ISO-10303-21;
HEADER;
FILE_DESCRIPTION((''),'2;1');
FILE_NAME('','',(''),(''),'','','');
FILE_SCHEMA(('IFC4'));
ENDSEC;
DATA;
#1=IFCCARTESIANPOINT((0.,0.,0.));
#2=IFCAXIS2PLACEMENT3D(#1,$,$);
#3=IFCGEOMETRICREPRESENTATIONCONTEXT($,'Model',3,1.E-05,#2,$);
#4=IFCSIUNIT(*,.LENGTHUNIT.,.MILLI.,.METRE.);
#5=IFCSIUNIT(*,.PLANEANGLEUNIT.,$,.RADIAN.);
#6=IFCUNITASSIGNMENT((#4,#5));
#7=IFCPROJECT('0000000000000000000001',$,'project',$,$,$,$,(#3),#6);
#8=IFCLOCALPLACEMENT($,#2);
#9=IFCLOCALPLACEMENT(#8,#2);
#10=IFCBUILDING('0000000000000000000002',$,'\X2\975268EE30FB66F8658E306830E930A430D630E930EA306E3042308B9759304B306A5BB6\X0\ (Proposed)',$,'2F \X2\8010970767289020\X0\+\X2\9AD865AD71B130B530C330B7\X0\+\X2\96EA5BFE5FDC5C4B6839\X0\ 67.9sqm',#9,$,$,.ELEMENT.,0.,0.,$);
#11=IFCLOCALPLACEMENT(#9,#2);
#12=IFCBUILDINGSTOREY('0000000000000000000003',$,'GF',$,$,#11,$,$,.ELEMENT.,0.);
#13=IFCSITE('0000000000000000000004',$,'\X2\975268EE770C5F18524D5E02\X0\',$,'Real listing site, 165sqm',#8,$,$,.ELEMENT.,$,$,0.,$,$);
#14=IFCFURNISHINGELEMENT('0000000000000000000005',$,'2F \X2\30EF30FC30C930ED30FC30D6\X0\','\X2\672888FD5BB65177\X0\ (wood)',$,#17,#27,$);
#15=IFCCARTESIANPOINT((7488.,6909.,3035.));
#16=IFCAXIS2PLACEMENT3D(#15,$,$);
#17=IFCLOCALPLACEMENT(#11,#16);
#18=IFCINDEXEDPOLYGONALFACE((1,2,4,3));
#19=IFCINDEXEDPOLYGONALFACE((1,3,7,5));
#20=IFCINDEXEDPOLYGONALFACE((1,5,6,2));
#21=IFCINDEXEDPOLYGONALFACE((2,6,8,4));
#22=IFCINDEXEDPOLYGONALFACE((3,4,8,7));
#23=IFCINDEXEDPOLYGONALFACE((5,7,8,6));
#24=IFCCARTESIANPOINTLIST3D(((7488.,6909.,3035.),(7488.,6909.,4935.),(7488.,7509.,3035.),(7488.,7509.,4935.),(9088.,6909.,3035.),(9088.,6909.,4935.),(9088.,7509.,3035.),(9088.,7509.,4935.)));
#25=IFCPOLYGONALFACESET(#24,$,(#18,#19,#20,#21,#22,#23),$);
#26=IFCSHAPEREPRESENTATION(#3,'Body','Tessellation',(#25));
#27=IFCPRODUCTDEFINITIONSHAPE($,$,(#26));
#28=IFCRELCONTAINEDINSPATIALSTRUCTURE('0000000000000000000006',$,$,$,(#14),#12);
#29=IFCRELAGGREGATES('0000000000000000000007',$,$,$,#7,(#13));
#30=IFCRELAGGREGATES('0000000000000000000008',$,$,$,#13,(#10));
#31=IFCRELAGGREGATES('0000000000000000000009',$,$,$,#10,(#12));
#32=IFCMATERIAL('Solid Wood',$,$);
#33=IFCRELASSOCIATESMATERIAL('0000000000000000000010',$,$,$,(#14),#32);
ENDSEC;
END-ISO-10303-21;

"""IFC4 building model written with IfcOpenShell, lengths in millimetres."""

from ifc_helpers import new_model, si_unit, frame, frame_2d, origin, place, context, project, spatial, rectangle, extrude, material, element, save


model = new_model("IFC4")

# Units and contexts
model_context = context("Model", 3, precision=1e-05, world=origin())
ifc_project = project(units=[si_unit("LENGTHUNIT", "METRE", prefix="MILLI"), si_unit("PLANEANGLEUNIT", "RADIAN")], contexts=[model_context])

# Site, building, storey
site_placement = place(None, origin())
site = spatial("IfcSite", under=ifc_project, at=site_placement, Name="青森県弘前市", ObjectType="Real listing site, 165sqm", CompositionType="ELEMENT", RefElevation=0.0)
building_placement = place(site_placement, origin())
building = spatial("IfcBuilding", under=site, at=building_placement, Name="青森・書斎とライブラリのある静かな家 (Proposed)", ObjectType="2F 耐震木造+高断熱サッシ+雪対応屋根 67.9sqm", CompositionType="ELEMENT", ElevationOfRefHeight=0.0, ElevationOfTerrain=0.0)
storey_placement = place(building_placement, origin())
storey = spatial("IfcBuildingStorey", under=building, at=storey_placement, Name="GF", CompositionType="ELEMENT", Elevation=0.0)

# Shared definitions
ifc_material_1 = material(Name="Solid Wood")

# Furnishing element
furnishing_1_placement = place(storey_placement, frame((7488.0, 6909.0, 3035.0)))
element("IfcFurnishingElement", 1, at=furnishing_1_placement, inside=storey, material=ifc_material_1, Name="2F ワードローブ", Description="木製家具 (wood)", context=model_context, shape_type="SweptSolid", body=[
    extrude(rectangle(XDim=1600.0, YDim=600.0, at=frame_2d((800.0, 300.0))), frame((7488.0, 6909.0, 3035.0)), (0.0, 0.0, 1.0), 1900.0),
])

save(model, "model.ifc")
